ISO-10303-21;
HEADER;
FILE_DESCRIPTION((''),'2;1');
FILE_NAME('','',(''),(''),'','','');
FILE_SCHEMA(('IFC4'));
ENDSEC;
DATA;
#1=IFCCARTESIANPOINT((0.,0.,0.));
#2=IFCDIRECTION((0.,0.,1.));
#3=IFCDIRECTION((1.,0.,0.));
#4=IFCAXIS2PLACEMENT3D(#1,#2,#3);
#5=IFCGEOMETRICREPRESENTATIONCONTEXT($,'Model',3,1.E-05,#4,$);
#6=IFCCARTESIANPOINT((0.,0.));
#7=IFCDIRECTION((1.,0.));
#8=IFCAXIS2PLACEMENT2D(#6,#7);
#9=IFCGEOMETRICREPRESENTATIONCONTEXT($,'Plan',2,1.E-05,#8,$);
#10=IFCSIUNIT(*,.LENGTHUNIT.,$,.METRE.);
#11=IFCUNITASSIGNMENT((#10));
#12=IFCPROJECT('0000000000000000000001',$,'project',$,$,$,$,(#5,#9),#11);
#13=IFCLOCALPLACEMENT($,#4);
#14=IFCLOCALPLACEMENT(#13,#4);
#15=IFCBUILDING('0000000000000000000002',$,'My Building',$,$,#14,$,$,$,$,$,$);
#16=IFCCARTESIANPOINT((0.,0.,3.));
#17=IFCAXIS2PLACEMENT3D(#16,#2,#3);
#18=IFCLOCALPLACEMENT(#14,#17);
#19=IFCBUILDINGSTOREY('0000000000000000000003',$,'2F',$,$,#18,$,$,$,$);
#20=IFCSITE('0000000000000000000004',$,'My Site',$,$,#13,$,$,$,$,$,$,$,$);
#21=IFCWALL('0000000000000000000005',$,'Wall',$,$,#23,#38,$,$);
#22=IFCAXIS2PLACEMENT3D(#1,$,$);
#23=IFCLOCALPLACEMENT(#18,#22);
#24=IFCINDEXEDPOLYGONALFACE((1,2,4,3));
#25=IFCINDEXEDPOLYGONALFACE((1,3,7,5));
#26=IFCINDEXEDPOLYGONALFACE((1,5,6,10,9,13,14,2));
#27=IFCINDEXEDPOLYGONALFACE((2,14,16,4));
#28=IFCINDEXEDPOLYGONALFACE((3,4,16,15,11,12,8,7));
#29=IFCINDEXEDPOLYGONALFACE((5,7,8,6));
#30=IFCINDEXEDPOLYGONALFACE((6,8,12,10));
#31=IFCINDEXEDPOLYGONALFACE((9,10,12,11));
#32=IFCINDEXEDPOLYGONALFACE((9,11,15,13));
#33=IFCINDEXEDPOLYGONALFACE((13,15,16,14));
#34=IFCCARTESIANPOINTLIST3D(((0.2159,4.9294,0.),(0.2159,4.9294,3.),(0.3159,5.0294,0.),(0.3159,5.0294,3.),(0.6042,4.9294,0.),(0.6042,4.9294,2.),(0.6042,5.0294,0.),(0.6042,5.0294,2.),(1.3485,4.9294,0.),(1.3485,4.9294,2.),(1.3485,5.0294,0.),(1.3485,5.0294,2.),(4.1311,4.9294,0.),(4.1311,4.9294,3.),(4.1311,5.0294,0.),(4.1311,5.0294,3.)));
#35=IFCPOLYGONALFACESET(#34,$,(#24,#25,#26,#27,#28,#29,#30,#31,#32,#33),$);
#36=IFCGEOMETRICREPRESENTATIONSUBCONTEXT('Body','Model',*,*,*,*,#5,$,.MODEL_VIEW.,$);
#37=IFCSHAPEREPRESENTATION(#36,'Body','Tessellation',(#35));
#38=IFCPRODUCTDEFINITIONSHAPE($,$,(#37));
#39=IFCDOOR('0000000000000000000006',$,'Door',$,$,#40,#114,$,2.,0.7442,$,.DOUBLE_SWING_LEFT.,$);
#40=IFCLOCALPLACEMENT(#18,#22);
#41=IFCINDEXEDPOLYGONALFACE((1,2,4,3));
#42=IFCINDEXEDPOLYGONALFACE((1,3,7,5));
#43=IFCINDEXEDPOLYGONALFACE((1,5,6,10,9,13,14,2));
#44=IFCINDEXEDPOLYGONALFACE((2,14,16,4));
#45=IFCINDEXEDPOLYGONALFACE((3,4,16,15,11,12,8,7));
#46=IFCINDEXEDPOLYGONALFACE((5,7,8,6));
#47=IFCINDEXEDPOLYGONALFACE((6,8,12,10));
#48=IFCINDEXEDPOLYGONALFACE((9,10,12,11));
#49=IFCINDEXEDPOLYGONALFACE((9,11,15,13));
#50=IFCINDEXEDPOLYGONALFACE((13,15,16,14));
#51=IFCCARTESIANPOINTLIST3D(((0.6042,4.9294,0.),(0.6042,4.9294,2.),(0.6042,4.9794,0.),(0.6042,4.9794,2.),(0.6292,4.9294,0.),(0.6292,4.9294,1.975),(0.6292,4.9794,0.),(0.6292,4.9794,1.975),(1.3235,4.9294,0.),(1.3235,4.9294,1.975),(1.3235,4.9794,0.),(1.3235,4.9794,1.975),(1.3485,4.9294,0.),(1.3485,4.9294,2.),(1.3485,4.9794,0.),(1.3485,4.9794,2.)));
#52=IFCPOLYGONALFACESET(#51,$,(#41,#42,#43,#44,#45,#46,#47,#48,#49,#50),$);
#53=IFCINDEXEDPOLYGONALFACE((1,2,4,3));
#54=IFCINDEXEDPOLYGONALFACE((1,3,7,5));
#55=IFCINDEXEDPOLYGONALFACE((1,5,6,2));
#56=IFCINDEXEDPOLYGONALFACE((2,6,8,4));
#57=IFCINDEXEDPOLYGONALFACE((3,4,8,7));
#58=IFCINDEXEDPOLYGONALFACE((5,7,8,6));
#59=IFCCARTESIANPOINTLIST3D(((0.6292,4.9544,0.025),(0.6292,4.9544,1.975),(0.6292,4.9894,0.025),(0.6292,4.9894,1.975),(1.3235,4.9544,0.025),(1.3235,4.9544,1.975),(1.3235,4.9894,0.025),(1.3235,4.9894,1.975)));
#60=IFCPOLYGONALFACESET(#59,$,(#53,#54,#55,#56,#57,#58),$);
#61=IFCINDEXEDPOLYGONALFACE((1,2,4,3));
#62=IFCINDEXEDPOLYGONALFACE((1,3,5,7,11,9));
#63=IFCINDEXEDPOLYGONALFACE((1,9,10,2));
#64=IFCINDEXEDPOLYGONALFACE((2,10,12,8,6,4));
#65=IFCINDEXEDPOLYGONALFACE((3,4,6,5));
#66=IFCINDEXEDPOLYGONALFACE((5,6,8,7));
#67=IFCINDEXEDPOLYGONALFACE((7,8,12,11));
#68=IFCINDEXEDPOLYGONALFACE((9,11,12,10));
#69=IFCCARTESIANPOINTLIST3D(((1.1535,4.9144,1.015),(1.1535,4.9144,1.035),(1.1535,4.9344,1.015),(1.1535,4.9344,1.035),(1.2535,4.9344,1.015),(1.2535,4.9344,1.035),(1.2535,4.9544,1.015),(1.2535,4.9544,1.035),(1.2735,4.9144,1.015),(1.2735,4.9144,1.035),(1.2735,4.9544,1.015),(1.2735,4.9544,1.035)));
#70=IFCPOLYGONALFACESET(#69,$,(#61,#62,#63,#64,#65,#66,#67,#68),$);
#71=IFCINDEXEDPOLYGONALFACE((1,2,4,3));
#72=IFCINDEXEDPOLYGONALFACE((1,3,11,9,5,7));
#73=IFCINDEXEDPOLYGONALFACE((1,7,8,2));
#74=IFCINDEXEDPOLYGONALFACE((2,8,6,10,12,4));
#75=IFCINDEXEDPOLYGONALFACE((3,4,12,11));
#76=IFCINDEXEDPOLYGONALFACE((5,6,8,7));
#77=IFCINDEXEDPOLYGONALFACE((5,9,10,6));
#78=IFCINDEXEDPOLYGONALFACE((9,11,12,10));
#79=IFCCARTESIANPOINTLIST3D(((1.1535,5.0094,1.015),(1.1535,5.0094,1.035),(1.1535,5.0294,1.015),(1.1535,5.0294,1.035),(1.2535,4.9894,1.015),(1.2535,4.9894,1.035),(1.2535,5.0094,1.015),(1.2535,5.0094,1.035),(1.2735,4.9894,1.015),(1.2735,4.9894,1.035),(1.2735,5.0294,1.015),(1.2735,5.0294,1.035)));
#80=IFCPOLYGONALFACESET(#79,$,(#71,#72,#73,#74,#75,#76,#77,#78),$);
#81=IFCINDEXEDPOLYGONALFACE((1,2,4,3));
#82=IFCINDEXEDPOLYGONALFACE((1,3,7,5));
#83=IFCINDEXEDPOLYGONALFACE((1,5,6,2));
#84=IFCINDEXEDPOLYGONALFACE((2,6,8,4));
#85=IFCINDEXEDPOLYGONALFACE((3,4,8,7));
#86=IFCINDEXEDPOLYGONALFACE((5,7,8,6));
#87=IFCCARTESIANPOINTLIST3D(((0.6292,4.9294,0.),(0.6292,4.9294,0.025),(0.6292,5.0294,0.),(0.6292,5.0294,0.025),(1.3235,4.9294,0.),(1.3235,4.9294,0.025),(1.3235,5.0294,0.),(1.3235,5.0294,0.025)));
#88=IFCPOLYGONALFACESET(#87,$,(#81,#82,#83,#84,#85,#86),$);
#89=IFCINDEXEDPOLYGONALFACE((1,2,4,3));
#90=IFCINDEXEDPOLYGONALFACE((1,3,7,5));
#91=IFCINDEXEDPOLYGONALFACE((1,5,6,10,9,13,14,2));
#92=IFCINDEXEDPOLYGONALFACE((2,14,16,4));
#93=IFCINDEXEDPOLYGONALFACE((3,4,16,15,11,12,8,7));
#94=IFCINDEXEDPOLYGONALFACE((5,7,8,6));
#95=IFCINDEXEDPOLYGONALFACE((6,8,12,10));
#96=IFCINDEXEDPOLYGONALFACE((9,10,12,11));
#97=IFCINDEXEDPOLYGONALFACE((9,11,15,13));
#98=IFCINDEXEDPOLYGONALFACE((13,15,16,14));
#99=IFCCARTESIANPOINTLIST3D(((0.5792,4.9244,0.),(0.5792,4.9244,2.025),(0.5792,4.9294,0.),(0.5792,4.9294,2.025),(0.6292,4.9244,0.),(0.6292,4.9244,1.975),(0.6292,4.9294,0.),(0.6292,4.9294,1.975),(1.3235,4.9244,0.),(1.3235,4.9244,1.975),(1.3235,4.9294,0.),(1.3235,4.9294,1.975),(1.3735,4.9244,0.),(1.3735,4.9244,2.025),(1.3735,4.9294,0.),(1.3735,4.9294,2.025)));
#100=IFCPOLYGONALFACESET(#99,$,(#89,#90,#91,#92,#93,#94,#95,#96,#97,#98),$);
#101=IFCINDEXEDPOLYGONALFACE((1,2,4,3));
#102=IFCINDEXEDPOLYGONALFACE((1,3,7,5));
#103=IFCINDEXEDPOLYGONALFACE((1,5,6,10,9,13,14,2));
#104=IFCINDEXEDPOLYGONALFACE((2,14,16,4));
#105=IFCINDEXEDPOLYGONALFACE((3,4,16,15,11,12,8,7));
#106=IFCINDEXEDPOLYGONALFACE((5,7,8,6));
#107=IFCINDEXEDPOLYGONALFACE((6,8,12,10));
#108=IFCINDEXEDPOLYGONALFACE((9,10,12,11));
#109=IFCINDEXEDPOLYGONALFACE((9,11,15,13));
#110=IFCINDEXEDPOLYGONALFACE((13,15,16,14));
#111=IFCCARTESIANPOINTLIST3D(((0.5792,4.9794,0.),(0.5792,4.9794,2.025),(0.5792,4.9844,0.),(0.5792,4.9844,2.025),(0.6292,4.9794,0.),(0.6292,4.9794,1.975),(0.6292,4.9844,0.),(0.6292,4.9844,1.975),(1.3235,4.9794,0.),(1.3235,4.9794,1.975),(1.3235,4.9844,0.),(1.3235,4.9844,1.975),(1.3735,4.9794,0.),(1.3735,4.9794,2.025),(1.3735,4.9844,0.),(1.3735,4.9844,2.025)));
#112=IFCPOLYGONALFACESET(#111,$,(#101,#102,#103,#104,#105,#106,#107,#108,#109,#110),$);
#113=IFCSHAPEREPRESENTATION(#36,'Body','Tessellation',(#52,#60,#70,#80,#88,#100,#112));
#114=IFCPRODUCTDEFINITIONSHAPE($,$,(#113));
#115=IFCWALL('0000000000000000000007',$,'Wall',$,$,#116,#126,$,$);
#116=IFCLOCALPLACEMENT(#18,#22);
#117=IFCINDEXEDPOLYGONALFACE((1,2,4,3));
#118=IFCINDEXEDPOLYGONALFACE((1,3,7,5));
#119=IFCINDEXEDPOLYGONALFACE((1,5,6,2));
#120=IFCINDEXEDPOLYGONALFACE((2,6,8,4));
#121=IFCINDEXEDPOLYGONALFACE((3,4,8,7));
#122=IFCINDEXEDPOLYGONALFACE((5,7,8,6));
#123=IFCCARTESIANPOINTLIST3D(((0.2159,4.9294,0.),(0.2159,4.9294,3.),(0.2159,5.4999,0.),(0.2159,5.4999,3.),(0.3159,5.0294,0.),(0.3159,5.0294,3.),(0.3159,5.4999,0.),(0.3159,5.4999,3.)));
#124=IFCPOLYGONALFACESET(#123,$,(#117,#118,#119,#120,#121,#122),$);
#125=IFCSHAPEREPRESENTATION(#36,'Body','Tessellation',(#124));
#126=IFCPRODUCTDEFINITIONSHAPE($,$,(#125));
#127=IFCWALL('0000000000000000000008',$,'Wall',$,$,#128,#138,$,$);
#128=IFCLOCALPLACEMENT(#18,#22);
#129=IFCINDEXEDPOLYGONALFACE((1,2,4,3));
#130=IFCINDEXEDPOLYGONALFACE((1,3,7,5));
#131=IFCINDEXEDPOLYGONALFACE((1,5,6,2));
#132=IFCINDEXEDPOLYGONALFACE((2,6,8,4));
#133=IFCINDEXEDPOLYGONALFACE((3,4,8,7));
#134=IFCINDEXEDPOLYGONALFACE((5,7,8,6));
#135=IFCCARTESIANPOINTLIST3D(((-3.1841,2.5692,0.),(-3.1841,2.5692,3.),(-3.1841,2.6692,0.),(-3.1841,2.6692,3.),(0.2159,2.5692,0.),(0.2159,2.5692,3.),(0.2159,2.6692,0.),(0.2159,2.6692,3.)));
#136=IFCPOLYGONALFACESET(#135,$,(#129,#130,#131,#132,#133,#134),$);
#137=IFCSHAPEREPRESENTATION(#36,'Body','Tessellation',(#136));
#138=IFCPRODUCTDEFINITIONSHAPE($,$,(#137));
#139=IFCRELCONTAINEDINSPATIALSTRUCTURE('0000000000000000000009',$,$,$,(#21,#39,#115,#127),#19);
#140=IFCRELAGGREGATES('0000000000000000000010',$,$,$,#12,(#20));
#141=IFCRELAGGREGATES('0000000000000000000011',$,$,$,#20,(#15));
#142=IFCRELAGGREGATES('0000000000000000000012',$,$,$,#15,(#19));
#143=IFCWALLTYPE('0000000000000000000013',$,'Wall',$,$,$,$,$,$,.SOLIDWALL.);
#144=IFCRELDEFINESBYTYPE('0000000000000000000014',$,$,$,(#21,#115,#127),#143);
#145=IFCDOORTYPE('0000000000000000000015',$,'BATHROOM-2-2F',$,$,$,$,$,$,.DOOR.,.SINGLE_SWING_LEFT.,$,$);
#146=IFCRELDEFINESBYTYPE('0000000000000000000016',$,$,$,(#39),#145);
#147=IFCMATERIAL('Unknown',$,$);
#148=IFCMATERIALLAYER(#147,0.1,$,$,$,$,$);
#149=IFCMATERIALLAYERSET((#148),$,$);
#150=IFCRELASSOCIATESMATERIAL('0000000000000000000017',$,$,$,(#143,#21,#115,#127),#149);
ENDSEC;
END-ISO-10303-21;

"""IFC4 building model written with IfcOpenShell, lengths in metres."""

from ifc_helpers import new_model, entity, si_unit, frame, origin_with_axes, origin_2d_with_axis, place, context, subcontext, project, spatial, line, indexed_curve, outline, extrude, shape, source, transform, mapped, material, layer, layer_set, layer_usage, type_object, type_shapes, element, fill, save


model = new_model("IFC4")

# Units and contexts
model_context = context("Model", 3, precision=1e-05, world=origin_with_axes())
plan_context = context("Plan", 2, precision=1e-05, world=origin_2d_with_axis())
body_context_1 = subcontext(model_context, "Body", "Model", "MODEL_VIEW")
body_context_2 = subcontext(plan_context, "Body", "Plan", "PLAN_VIEW")
ifc_project = project(units=[si_unit("LENGTHUNIT", "METRE")], contexts=[model_context, plan_context])

# Site, building, storey
site_placement = place(None, origin_with_axes())
site = spatial("IfcSite", under=ifc_project, at=site_placement, Name="My Site")
building_placement = place(site_placement, origin_with_axes())
building = spatial("IfcBuilding", under=site, at=building_placement, Name="My Building")
storey_placement = place(building_placement, frame((0.0, 0.0, 3.0), z_axis=(0.0, 0.0, 1.0), x_axis=(1.0, 0.0, 0.0)))
storey = spatial("IfcBuildingStorey", under=building, at=storey_placement, Name="2F")

# Shared definitions
ifc_material = material(Name="Unknown")

# Shared definitions
ifc_layer_1 = layer(ifc_material, 0.1)
ifc_layer_set_1 = layer_set([ifc_layer_1])
wall_type = type_object("IfcWallType", Name="Wall", PredefinedType="SOLIDWALL", material=ifc_layer_set_1)

# Wall, opening, door
ifc_layer_usage_1 = layer_usage(ifc_layer_set_1, "AXIS2", "POSITIVE", 0.0)
wall_1_placement = place(storey_placement, frame((4.1311, 5.0294, 0.0), z_axis=(0.0, 0.0, 1.0), x_axis=(-1.0, 0.0, 0.0)))
wall_1 = element("IfcWall", 1, at=wall_1_placement, inside=storey, type_object=wall_type, material=ifc_layer_usage_1, Name="Wall", context=body_context_1, shape_type="SweptSolid", body=[
    extrude(outline(indexed_curve([(0.0, 0.0), (0.0, 0.1), (3.9153, 0.1), (3.8153, 0.0)], segments=[line(1, 2, 3, 4, 1)])), origin_with_axes(), (0.0, 0.0, 1.0), 3.0),
])
shared_shape_1 = source(origin_with_axes(), body_context_1, "Body", "SweptSolid", [
    extrude(outline(indexed_curve([(0.0, 0.0), (0.7442, 0.0), (0.7442, 2.0), (0.0, 2.0)], segments=[line(1, 2, 3, 4, 1)])), frame((0.0, -0.6, 0.0), z_axis=(0.0, -1.0, 0.0), x_axis=(1.0, 0.0, 0.0)), (0.0, 0.0, -1.0), 1.2),
])
opening_1_placement = place(wall_1_placement, frame((3.5269, 0.1, 0.0), z_axis=(0.0, 0.0, 1.0), x_axis=(-1.0, 0.0, 0.0)))
opening_1 = element("IfcOpeningElement", 2, at=opening_1_placement, cuts=wall_1, PredefinedType="OPENING", context=body_context_1, shape_type="MappedRepresentation", body=[
    mapped(shared_shape_1, transform((0.0, 0.0, 0.0), x_axis=(1.0, 0.0, 0.0), y_axis=(0.0, 1.0, 0.0), z_axis=(0.0, 0.0, 1.0), scale=1.0)),
])
door_type_1 = type_object("IfcDoorType", Name="BATHROOM-2-2F", OperationType="SINGLE_SWING_LEFT", PredefinedType="DOOR")
shared_shape_2 = source(origin_with_axes(), body_context_1, "Body", "SweptSolid", [
    extrude(outline(indexed_curve([(0.0, 0.0), (0.0, 2.0), (0.7442, 2.0), (0.7442, 0.0), (0.7192, 0.0), (0.7192, 1.975), (0.025, 1.975), (0.025, 0.0)], segments=[line(1, 2, 3, 4, 5, 6, 7, 8, 1)])), frame((0.0, 0.0, 0.0), z_axis=(0.0, -1.0, 0.0), x_axis=(1.0, 0.0, 0.0)), (0.0, 0.0, -1.0), 0.05),
    extrude(outline(indexed_curve([(0.0, 0.0), (0.6942, 0.0), (0.6942, 0.035), (0.0, 0.035)], segments=[line(1, 2, 3, 4, 1)])), frame((0.025, 0.025, 0.025), z_axis=(0.0, 0.0, 1.0), x_axis=(1.0, 0.0, 0.0)), (0.0, 0.0, 1.0), 1.95),
    extrude(outline(indexed_curve([(0.0, 0.0), (0.0, -0.04), (-0.12, -0.04), (-0.12, -0.02), (-0.02, -0.02), (-0.02, 0.0)], segments=[line(1, 2, 3, 4, 5, 6, 1)])), frame((0.6692, 0.025, 1.015), z_axis=(0.0, 0.0, 1.0), x_axis=(1.0, 0.0, 0.0)), (0.0, 0.0, 1.0), 0.02),
    extrude(outline(indexed_curve([(0.0, 0.0), (0.0, 0.04), (-0.12, 0.04), (-0.12, 0.02), (-0.02, 0.02), (-0.02, 0.0)], segments=[line(1, 2, 3, 4, 5, 6, 1)])), frame((0.6692, 0.06, 1.015), z_axis=(0.0, 0.0, 1.0), x_axis=(1.0, 0.0, 0.0)), (0.0, 0.0, 1.0), 0.02),
    extrude(outline(indexed_curve([(0.0, 0.0), (0.6942, 0.0), (0.6942, 0.1), (0.0, 0.1)], segments=[line(1, 2, 3, 4, 1)])), frame((0.025, 0.0, 0.0), z_axis=(0.0, 0.0, 1.0), x_axis=(1.0, 0.0, 0.0)), (0.0, 0.0, 1.0), 0.025),
    extrude(outline(indexed_curve([(0.0, 0.0), (0.0, 2.025), (0.7942, 2.025), (0.7942, 0.0), (0.7442, 0.0), (0.7442, 1.975), (0.05, 1.975), (0.05, 0.0)], segments=[line(1, 2, 3, 4, 5, 6, 7, 8, 1)])), frame((-0.025, -0.005, 0.0), z_axis=(0.0, -1.0, 0.0), x_axis=(1.0, 0.0, 0.0)), (0.0, 0.0, -1.0), 0.005),
    extrude(outline(indexed_curve([(0.0, 0.0), (0.0, 2.025), (0.7942, 2.025), (0.7942, 0.0), (0.7442, 0.0), (0.7442, 1.975), (0.05, 1.975), (0.05, 0.0)], segments=[line(1, 2, 3, 4, 5, 6, 7, 8, 1)])), frame((-0.025, 0.05, 0.0), z_axis=(0.0, -1.0, 0.0), x_axis=(1.0, 0.0, 0.0)), (0.0, 0.0, -1.0), 0.005),
])
shared_shape_3 = source(origin_with_axes(), body_context_2, "Body", "Curve2D", [
    entity("IfcIndexedPolyCurve", entity("IfcCartesianPointList2D", [[0.0, 0.0], [0.025, 0.0], [0.025, 0.05], [0.0, 0.05]]), [entity("IfcLineIndex", [1, 2, 3, 4, 1])]),
    entity("IfcIndexedPolyCurve", entity("IfcCartesianPointList2D", [[0.7442, 0.0], [0.7192, 0.0], [0.7192, 0.05], [0.7442, 0.05]]), [entity("IfcLineIndex", [1, 2, 3, 4, 1])]),
    entity("IfcIndexedPolyCurve", entity("IfcCartesianPointList2D", [[0.025, 0.05], [0.025, -0.6442], [0.06, -0.6442]])),
    entity("IfcTrimmedCurve", entity("IfcEllipse", entity("IfcAxis2Placement2D", entity("IfcCartesianPoint", [0.06, 0.05]), entity("IfcDirection", [1.0, 0.0])), 0.6592, 0.6942), [entity("IfcCartesianPoint", [0.06, -0.6442])], [entity("IfcCartesianPoint", [0.06, 0.7442])], True, "CARTESIAN"),
    entity("IfcIndexedPolyCurve", entity("IfcCartesianPointList2D", [[0.025, 0.05], [0.06, 0.05], [0.06, 0.7442], [0.025, 0.7442]]), [entity("IfcLineIndex", [1, 2, 3, 4, 1])]),
])
type_shapes(door_type_1, [shared_shape_2, shared_shape_3])
door_1_placement = place(opening_1_placement, frame((0.0, 0.0, 0.0), z_axis=(0.0, 0.0, 1.0), x_axis=(1.0, 0.0, 0.0)))
door_1 = element("IfcDoor", 3, at=door_1_placement, inside=storey, type_object=door_type_1, Name="Door", OperationType="DOUBLE_SWING_LEFT", OverallHeight=2.0, OverallWidth=0.7442, shapes=[
    shape(body_context_1, "Body", "MappedRepresentation", [mapped(shared_shape_2, transform((0.0, 0.0, 0.0), x_axis=(1.0, 0.0, 0.0), y_axis=(0.0, 1.0, 0.0), z_axis=(0.0, 0.0, 1.0), scale=1.0))]),
    shape(body_context_2, "Body", "MappedRepresentation", [mapped(shared_shape_3, transform((0.0, 0.0, 0.0), x_axis=(1.0, 0.0, 0.0), y_axis=(0.0, 1.0, 0.0), z_axis=(0.0, 0.0, 1.0), scale=1.0))]),
])
fill(opening_1, door_1)

# Wall
ifc_layer_usage_2 = layer_usage(ifc_layer_set_1, "AXIS2", "POSITIVE", 0.0)
wall_2_placement = place(storey_placement, frame((0.3159, 5.0294, 0.0), z_axis=(0.0, 0.0, 1.0), x_axis=(0.0, 1.0, 0.0)))
element("IfcWall", 4, at=wall_2_placement, inside=storey, type_object=wall_type, material=ifc_layer_usage_2, Name="Wall", context=body_context_1, shape_type="SweptSolid", body=[
    extrude(outline(indexed_curve([(0.0, 0.0), (-0.1, 0.1), (0.4705, 0.1), (0.4705, 0.0)], segments=[line(1, 2, 3, 4, 1)])), origin_with_axes(), (0.0, 0.0, 1.0), 3.0),
])

# Wall
ifc_layer_usage_3 = layer_usage(ifc_layer_set_1, "AXIS2", "POSITIVE", 0.0)
wall_3_placement = place(storey_placement, frame((-3.1841, 2.5692, 0.0), z_axis=(0.0, 0.0, 1.0), x_axis=(1.0, 0.0, 0.0)))
element("IfcWall", 5, at=wall_3_placement, inside=storey, type_object=wall_type, material=ifc_layer_usage_3, Name="Wall", context=body_context_1, shape_type="SweptSolid", body=[
    extrude(outline(indexed_curve([(0.0, 0.0), (0.0, 0.1), (3.4, 0.1), (3.4, 0.0)], segments=[line(1, 2, 3, 4, 1)])), origin_with_axes(), (0.0, 0.0, 1.0), 3.0),
])

save(model, "model.ifc")
